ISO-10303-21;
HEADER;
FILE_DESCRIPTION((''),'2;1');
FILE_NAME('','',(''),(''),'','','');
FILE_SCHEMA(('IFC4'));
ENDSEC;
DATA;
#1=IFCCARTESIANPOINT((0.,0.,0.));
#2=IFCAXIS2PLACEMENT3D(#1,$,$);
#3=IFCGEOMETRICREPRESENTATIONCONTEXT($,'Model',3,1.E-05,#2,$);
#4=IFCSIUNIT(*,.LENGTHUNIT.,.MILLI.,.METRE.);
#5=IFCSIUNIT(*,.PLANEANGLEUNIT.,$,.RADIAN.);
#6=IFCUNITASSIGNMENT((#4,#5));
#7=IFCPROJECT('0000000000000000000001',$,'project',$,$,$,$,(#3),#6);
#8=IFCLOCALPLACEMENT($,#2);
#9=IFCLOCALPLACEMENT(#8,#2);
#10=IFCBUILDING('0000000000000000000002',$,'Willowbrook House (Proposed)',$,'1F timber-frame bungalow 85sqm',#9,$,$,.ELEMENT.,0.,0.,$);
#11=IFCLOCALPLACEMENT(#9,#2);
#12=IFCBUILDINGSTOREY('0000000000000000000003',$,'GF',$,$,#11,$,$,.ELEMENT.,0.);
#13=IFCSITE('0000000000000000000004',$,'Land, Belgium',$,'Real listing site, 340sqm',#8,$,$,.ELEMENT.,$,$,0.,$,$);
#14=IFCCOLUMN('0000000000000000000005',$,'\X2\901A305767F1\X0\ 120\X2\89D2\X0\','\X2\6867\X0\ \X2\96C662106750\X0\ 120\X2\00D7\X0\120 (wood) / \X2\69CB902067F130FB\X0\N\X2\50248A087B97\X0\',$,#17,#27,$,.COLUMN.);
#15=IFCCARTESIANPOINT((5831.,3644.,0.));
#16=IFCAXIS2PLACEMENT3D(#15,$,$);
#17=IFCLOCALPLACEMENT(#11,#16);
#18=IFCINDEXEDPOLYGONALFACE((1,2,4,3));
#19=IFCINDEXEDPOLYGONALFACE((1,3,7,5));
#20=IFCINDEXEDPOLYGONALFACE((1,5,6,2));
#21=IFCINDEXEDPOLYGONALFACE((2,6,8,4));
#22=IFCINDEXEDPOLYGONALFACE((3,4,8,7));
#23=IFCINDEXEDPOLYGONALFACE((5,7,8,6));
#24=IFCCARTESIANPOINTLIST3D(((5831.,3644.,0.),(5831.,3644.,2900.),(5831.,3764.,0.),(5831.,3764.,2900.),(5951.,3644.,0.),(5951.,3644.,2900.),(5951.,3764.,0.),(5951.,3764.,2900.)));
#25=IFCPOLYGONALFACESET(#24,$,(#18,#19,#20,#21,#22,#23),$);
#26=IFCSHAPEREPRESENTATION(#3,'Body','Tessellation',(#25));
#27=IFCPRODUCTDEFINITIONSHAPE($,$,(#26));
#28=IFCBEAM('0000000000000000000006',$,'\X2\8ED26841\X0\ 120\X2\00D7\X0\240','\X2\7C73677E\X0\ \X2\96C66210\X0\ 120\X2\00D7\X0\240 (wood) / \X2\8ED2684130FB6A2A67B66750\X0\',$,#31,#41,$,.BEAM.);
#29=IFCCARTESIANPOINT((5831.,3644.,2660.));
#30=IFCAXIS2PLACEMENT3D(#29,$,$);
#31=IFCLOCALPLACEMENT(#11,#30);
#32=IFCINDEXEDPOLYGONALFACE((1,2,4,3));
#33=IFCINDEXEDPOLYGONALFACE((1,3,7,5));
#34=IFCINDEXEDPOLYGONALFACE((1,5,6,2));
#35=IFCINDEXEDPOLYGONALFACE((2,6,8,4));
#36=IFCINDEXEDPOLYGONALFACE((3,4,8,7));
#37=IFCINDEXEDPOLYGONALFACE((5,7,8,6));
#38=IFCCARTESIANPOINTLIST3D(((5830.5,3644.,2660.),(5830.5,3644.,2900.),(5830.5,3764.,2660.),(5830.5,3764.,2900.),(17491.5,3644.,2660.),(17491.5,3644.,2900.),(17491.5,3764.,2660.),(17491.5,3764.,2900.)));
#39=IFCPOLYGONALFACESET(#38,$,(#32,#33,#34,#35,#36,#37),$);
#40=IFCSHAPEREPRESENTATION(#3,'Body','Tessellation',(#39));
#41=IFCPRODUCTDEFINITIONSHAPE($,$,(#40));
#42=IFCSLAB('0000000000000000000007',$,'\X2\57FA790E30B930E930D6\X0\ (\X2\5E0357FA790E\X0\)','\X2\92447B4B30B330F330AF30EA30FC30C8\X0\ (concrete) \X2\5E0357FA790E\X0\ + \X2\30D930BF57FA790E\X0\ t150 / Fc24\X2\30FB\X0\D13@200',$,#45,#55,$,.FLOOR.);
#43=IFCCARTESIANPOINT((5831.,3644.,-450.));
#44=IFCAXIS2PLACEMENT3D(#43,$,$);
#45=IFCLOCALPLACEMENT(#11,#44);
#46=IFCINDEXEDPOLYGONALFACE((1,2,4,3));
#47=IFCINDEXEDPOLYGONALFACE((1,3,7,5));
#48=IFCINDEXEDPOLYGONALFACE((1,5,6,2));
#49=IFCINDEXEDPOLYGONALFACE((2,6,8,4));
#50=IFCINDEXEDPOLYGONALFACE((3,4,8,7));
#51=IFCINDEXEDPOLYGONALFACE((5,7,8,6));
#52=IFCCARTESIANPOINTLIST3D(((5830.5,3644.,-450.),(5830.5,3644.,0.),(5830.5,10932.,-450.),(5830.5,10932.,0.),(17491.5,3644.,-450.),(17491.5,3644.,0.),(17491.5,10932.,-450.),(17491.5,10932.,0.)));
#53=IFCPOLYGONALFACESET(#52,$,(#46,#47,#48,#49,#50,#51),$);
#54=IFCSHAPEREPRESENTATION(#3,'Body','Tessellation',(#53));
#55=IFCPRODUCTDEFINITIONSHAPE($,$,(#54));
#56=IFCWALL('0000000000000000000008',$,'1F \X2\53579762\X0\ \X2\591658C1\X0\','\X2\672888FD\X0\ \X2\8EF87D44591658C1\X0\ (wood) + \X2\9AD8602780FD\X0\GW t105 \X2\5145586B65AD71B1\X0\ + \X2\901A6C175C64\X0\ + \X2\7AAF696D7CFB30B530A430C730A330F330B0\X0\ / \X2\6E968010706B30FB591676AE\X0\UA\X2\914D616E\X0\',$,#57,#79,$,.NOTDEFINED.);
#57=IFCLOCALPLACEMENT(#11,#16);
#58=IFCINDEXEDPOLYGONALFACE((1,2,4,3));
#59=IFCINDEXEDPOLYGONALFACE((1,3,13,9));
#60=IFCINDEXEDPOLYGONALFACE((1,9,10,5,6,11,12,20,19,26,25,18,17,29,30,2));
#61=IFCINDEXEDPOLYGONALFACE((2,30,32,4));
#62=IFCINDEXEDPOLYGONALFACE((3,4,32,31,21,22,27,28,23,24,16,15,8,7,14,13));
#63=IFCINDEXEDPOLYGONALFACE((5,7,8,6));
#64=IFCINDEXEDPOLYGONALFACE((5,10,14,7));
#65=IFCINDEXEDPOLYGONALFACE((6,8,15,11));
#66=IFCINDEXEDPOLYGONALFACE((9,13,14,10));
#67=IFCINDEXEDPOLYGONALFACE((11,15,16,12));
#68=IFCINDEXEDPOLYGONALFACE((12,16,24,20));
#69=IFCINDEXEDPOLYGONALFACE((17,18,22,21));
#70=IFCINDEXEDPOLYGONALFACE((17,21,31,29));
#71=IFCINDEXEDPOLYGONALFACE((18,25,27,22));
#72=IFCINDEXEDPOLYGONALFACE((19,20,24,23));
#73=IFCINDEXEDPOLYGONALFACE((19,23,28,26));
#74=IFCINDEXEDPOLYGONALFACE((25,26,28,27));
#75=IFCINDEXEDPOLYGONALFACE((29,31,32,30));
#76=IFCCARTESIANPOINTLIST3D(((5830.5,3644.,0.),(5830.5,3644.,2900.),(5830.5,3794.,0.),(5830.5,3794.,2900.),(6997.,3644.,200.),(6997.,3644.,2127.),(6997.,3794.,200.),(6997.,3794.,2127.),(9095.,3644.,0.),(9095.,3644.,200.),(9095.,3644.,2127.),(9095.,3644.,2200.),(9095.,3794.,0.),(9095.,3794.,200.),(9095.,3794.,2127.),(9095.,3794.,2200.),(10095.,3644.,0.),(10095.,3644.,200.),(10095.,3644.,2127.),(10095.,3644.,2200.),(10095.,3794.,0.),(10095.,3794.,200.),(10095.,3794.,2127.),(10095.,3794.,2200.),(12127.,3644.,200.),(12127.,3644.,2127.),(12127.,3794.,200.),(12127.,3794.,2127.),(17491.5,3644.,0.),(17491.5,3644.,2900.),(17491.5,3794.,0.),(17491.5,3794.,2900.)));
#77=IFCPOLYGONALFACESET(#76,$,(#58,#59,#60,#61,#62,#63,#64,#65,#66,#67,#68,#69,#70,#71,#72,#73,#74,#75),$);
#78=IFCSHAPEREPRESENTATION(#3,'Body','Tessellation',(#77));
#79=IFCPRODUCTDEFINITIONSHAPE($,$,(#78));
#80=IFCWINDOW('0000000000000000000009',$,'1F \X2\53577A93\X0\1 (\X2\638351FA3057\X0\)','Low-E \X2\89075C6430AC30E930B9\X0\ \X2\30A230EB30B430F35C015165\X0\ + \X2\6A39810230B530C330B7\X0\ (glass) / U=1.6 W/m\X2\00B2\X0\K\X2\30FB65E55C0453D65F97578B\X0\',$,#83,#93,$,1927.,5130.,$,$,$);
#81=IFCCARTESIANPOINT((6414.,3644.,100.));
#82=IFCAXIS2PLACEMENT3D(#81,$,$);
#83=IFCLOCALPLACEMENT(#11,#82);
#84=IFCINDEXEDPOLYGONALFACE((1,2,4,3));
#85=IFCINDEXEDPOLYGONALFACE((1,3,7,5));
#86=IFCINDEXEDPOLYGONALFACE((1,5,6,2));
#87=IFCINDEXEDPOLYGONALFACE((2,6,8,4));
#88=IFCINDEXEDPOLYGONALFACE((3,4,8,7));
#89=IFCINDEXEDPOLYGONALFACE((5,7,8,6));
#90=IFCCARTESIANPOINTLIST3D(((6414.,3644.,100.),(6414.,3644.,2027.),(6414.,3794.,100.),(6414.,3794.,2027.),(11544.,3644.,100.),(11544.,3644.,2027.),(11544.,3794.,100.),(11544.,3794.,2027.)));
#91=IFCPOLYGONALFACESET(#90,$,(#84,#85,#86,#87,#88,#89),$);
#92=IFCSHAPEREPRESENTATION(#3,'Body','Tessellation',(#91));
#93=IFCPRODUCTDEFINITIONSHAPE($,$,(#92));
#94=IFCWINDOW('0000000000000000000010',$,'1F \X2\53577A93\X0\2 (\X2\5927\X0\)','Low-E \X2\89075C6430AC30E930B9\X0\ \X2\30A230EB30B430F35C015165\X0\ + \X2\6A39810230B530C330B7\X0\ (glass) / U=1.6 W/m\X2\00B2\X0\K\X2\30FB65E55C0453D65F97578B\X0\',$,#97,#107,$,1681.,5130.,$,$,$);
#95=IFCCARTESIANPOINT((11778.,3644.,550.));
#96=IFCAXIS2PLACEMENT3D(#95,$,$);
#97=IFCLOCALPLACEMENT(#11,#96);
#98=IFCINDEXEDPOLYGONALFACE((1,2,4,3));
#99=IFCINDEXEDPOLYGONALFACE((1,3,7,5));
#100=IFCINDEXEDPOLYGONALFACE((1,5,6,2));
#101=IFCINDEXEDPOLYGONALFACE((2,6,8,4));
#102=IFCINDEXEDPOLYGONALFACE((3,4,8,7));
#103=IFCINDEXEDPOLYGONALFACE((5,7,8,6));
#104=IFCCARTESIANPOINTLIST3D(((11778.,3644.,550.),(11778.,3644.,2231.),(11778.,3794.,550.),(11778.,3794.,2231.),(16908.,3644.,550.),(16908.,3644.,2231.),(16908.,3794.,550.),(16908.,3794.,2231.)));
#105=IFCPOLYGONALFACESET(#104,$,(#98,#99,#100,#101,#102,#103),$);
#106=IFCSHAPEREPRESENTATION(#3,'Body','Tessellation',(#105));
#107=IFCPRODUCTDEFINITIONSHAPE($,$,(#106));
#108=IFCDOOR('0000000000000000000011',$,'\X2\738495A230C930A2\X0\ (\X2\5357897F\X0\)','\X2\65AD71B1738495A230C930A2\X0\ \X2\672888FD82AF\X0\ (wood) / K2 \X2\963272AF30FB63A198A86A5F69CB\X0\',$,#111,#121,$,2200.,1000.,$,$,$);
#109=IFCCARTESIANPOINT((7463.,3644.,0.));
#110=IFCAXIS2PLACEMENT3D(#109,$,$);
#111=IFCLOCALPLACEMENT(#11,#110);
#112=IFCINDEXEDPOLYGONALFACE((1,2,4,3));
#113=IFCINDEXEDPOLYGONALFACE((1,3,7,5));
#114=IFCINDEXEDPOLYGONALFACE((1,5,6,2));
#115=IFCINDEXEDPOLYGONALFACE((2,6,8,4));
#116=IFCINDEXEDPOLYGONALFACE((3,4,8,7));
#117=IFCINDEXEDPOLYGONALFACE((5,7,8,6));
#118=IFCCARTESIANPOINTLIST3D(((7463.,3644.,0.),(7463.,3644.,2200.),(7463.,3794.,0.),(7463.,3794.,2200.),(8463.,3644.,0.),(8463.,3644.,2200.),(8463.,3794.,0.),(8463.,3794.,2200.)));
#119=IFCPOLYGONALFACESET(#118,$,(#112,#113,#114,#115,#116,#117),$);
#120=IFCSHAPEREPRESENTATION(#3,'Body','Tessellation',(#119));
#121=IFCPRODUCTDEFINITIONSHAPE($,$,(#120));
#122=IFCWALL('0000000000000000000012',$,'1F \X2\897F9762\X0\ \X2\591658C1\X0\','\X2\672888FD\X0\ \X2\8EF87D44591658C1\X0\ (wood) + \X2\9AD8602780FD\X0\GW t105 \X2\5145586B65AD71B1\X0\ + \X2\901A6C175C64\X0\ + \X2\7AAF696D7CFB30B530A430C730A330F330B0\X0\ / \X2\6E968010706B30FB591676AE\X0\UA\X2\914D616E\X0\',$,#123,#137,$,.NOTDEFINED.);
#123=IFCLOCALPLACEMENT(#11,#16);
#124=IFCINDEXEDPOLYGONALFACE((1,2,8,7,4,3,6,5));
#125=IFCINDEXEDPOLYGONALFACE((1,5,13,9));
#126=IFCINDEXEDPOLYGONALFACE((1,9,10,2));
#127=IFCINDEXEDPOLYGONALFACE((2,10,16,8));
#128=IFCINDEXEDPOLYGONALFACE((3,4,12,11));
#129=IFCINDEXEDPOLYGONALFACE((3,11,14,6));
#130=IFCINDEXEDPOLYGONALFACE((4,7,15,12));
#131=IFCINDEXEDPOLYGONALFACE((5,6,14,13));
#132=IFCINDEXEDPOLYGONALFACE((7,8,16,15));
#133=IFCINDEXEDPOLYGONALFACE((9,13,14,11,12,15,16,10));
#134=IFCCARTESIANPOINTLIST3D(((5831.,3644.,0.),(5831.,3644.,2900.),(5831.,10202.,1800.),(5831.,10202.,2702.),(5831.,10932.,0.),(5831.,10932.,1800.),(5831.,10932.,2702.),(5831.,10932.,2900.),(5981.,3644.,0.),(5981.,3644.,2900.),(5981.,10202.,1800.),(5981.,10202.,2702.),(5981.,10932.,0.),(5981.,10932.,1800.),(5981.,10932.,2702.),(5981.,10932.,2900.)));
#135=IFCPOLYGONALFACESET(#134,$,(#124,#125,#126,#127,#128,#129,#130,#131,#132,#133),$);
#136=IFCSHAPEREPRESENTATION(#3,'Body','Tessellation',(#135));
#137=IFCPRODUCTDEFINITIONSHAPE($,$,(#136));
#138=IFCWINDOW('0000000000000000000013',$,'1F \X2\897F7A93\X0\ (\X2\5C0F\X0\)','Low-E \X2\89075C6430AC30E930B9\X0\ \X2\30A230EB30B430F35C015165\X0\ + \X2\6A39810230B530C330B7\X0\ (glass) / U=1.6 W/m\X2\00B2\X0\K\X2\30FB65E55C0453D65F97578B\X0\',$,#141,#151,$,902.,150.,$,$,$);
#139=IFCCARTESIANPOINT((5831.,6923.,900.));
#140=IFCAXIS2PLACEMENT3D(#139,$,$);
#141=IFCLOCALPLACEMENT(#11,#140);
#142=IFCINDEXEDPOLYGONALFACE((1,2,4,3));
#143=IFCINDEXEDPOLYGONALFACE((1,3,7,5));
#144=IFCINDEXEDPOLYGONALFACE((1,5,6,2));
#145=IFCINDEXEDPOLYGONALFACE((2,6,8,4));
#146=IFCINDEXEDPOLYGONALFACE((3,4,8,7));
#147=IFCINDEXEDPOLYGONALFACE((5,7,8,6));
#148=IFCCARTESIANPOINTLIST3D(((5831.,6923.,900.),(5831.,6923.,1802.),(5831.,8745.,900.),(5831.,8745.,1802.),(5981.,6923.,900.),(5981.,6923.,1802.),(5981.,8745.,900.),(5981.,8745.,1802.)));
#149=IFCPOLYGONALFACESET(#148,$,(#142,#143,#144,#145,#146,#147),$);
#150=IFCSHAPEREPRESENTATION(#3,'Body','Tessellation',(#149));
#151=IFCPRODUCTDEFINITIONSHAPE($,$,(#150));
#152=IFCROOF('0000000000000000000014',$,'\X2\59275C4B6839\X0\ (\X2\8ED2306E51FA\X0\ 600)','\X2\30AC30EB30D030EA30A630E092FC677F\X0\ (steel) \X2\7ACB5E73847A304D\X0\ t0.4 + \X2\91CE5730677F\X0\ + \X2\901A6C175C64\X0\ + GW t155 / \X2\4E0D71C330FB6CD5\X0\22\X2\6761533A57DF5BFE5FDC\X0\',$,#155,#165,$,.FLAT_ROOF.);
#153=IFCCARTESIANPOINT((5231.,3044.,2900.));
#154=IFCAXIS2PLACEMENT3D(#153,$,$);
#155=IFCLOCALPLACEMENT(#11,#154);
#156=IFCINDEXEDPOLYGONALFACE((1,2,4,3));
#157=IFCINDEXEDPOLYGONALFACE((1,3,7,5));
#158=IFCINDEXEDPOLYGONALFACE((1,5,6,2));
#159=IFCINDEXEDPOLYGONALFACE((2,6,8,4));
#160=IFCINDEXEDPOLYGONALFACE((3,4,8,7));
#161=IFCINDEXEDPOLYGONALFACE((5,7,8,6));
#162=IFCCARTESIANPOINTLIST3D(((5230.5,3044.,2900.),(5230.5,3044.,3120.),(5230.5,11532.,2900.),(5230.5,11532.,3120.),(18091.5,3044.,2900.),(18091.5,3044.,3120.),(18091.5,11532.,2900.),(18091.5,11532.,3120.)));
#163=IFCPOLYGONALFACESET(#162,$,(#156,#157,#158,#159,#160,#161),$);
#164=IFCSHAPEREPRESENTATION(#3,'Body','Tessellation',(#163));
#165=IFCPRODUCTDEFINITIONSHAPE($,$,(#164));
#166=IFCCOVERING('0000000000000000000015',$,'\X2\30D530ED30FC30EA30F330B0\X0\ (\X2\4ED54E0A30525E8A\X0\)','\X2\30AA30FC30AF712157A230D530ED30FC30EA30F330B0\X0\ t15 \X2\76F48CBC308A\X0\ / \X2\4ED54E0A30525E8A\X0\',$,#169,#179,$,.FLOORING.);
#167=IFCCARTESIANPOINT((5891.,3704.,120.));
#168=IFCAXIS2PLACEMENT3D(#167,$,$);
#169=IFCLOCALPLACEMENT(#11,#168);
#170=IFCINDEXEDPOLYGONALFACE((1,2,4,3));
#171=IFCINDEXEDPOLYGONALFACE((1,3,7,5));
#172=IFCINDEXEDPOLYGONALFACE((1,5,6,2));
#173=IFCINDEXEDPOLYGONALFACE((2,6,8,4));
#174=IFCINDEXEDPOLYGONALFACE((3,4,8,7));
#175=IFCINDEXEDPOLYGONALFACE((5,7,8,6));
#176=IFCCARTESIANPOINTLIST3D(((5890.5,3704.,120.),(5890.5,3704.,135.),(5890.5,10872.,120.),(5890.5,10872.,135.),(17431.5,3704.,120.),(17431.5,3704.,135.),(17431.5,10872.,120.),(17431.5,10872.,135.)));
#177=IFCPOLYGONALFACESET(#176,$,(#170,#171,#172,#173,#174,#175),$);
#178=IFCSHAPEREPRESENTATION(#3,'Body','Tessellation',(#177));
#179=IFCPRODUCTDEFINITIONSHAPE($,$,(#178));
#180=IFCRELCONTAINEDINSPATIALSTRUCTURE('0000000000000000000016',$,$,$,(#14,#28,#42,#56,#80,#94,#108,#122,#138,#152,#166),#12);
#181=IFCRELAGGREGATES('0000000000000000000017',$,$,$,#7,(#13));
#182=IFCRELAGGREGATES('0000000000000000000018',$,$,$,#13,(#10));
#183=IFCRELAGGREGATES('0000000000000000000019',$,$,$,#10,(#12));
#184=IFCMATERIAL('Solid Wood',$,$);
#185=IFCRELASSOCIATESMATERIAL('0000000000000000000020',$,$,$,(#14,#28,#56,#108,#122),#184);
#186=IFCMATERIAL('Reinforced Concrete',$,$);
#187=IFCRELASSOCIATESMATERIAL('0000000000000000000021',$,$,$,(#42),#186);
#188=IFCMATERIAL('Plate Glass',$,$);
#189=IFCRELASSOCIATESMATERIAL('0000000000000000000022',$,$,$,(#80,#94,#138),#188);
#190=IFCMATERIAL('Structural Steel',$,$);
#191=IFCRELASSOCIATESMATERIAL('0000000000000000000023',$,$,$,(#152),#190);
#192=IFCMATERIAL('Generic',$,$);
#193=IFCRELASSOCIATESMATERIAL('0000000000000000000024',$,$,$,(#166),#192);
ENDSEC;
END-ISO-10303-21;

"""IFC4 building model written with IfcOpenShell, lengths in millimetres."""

from ifc_helpers import new_model, si_unit, frame, frame_2d, origin, place, context, project, spatial, rectangle, extrude, material, element, fill, save


model = new_model("IFC4")

# Units and contexts
model_context = context("Model", 3, precision=1e-05, world=origin())
ifc_project = project(units=[si_unit("LENGTHUNIT", "METRE", prefix="MILLI"), si_unit("PLANEANGLEUNIT", "RADIAN")], contexts=[model_context])

# Site, building, storey
site_placement = place(None, origin())
site = spatial("IfcSite", under=ifc_project, at=site_placement, Name="Land, Belgium", ObjectType="Real listing site, 340sqm", CompositionType="ELEMENT", RefElevation=0.0)
building_placement = place(site_placement, origin())
building = spatial("IfcBuilding", under=site, at=building_placement, Name="Willowbrook House (Proposed)", ObjectType="1F timber-frame bungalow 85sqm", CompositionType="ELEMENT", ElevationOfRefHeight=0.0, ElevationOfTerrain=0.0)
storey_placement = place(building_placement, origin())
storey = spatial("IfcBuildingStorey", under=building, at=storey_placement, Name="GF", CompositionType="ELEMENT", Elevation=0.0)

# Column
ifc_material_1 = material(Name="Solid Wood")
column_1_placement = place(storey_placement, frame((5831.0, 3644.0, 0.0)))
element("IfcColumn", 1, at=column_1_placement, inside=storey, material=ifc_material_1, Name="通し柱 120角", Description="桧 集成材 120×120 (wood) / 構造柱・N値計算", PredefinedType="COLUMN", context=model_context, shape_type="SweptSolid", body=[
    extrude(rectangle(XDim=120.0, YDim=120.0, at=frame_2d((60.0, 60.0))), frame((5831.0, 3644.0, 0.0)), (0.0, 0.0, 1.0), 2900.0),
])

# Beam
beam_1_placement = place(storey_placement, frame((5831.0, 3644.0, 2660.0)))
element("IfcBeam", 2, at=beam_1_placement, inside=storey, material=ifc_material_1, Name="軒桁 120×240", Description="米松 集成 120×240 (wood) / 軒桁・横架材", PredefinedType="BEAM", context=model_context, shape_type="SweptSolid", body=[
    extrude(rectangle(XDim=11661.0, YDim=120.0, at=frame_2d((5830.0, 60.0))), frame((5831.0, 3644.0, 2660.0)), (0.0, 0.0, 1.0), 240.0),
])

# Slab
ifc_material_2 = material(Name="Reinforced Concrete")
slab_1_placement = place(storey_placement, frame((5831.0, 3644.0, -450.0)))
element("IfcSlab", 3, at=slab_1_placement, inside=storey, material=ifc_material_2, Name="基礎スラブ (布基礎)", Description="鉄筋コンクリート (concrete) 布基礎 + ベタ基礎 t150 / Fc24・D13@200", PredefinedType="FLOOR", context=model_context, shape_type="SweptSolid", body=[
    extrude(rectangle(XDim=11661.0, YDim=7288.0, at=frame_2d((5830.0, 3644.0))), frame((5831.0, 3644.0, -450.0)), (0.0, 0.0, 1.0), 450.0),
])

# Wall, openings, windows, door
wall_1_placement = place(storey_placement, frame((5831.0, 3644.0, 0.0)))
wall_1 = element("IfcWall", 4, at=wall_1_placement, inside=storey, material=ifc_material_1, Name="1F 南面 外壁", Description="木製 軸組外壁 (wood) + 高性能GW t105 充填断熱 + 通気層 + 窯業系サイディング / 準耐火・外皮UA配慮", PredefinedType="NOTDEFINED", context=model_context, shape_type="SweptSolid", body=[
    extrude(rectangle(XDim=11661.0, YDim=150.0, at=frame_2d((5830.0, 75.0))), frame((5831.0, 3644.0, 0.0)), (0.0, 0.0, 1.0), 2900.0),
])
opening_1_placement = place(storey_placement, frame((6414.0, 3644.0, 100.0)))
opening_1 = element("IfcOpeningElement", 5, at=opening_1_placement, cuts=wall_1, PredefinedType="NOTDEFINED", context=model_context, shape_type="SweptSolid", body=[
    extrude(rectangle(XDim=5130.0, YDim=150.0, at=frame_2d((2565.0, 75.0))), frame((6414.0, 3644.0, 100.0)), (0.0, 0.0, 1.0), 1927.0),
])
opening_2_placement = place(storey_placement, frame((11778.0, 3644.0, 550.0)))
opening_2 = element("IfcOpeningElement", 6, at=opening_2_placement, cuts=wall_1, PredefinedType="NOTDEFINED", context=model_context, shape_type="SweptSolid", body=[
    extrude(rectangle(XDim=5130.0, YDim=150.0, at=frame_2d((2565.0, 75.0))), frame((11778.0, 3644.0, 550.0)), (0.0, 0.0, 1.0), 1681.0),
])
opening_3_placement = place(storey_placement, frame((7463.0, 3644.0, 0.0)))
opening_3 = element("IfcOpeningElement", 7, at=opening_3_placement, cuts=wall_1, PredefinedType="NOTDEFINED", context=model_context, shape_type="SweptSolid", body=[
    extrude(rectangle(XDim=1000.0, YDim=150.0, at=frame_2d((500.0, 75.0))), frame((7463.0, 3644.0, 0.0)), (0.0, 0.0, 1.0), 2200.0),
])
ifc_material_3 = material(Name="Plate Glass")
window_1_placement = place(storey_placement, frame((6414.0, 3644.0, 100.0)))
window_1 = element("IfcWindow", 8, at=window_1_placement, inside=storey, material=ifc_material_3, Name="1F 南窓1 (掃出し)", Description="Low-E 複層ガラス アルゴン封入 + 樹脂サッシ (glass) / U=1.6 W/m²K・日射取得型", OverallHeight=1927.0, OverallWidth=5130.0, context=model_context, shape_type="SweptSolid", body=[
    extrude(rectangle(XDim=5130.0, YDim=150.0, at=frame_2d((2565.0, 75.0))), frame((6414.0, 3644.0, 100.0)), (0.0, 0.0, 1.0), 1927.0),
])
fill(opening_1, window_1)
window_2_placement = place(storey_placement, frame((11778.0, 3644.0, 550.0)))
window_2 = element("IfcWindow", 9, at=window_2_placement, inside=storey, material=ifc_material_3, Name="1F 南窓2 (大)", Description="Low-E 複層ガラス アルゴン封入 + 樹脂サッシ (glass) / U=1.6 W/m²K・日射取得型", OverallHeight=1681.0, OverallWidth=5130.0, context=model_context, shape_type="SweptSolid", body=[
    extrude(rectangle(XDim=5130.0, YDim=150.0, at=frame_2d((2565.0, 75.0))), frame((11778.0, 3644.0, 550.0)), (0.0, 0.0, 1.0), 1681.0),
])
fill(opening_2, window_2)
door_placement = place(storey_placement, frame((7463.0, 3644.0, 0.0)))
door = element("IfcDoor", 10, at=door_placement, inside=storey, material=ifc_material_1, Name="玄関ドア (南西)", Description="断熱玄関ドア 木製芯 (wood) / K2 防犯・採風機構", OverallHeight=2200.0, OverallWidth=1000.0, context=model_context, shape_type="SweptSolid", body=[
    extrude(rectangle(XDim=1000.0, YDim=150.0, at=frame_2d((500.0, 75.0))), frame((7463.0, 3644.0, 0.0)), (0.0, 0.0, 1.0), 2200.0),
])
fill(opening_3, door)

# Wall, opening, window
wall_2_placement = place(storey_placement, frame((5831.0, 3644.0, 0.0)))
wall_2 = element("IfcWall", 11, at=wall_2_placement, inside=storey, material=ifc_material_1, Name="1F 西面 外壁", Description="木製 軸組外壁 (wood) + 高性能GW t105 充填断熱 + 通気層 + 窯業系サイディング / 準耐火・外皮UA配慮", PredefinedType="NOTDEFINED", context=model_context, shape_type="SweptSolid", body=[
    extrude(rectangle(XDim=150.0, YDim=7288.0, at=frame_2d((75.0, 3644.0))), frame((5831.0, 3644.0, 0.0)), (0.0, 0.0, 1.0), 2900.0),
])
opening_4_placement = place(storey_placement, frame((5831.0, 6923.0, 900.0)))
opening_4 = element("IfcOpeningElement", 12, at=opening_4_placement, cuts=wall_2, PredefinedType="NOTDEFINED", context=model_context, shape_type="SweptSolid", body=[
    extrude(rectangle(XDim=150.0, YDim=1822.0, at=frame_2d((75.0, 911.0))), frame((5831.0, 6923.0, 900.0)), (0.0, 0.0, 1.0), 902.0),
])
window_3_placement = place(storey_placement, frame((5831.0, 6923.0, 900.0)))
window_3 = element("IfcWindow", 13, at=window_3_placement, inside=storey, material=ifc_material_3, Name="1F 西窓 (小)", Description="Low-E 複層ガラス アルゴン封入 + 樹脂サッシ (glass) / U=1.6 W/m²K・日射取得型", OverallHeight=902.0, OverallWidth=150.0, context=model_context, shape_type="SweptSolid", body=[
    extrude(rectangle(XDim=150.0, YDim=1822.0, at=frame_2d((75.0, 911.0))), frame((5831.0, 6923.0, 900.0)), (0.0, 0.0, 1.0), 902.0),
])
fill(opening_4, window_3)

# Roof
ifc_material_4 = material(Name="Structural Steel")
roof_placement = place(storey_placement, frame((5231.0, 3044.0, 2900.0)))
element("IfcRoof", 14, at=roof_placement, inside=storey, material=ifc_material_4, Name="大屋根 (軒の出 600)", Description="ガルバリウム鋼板 (steel) 立平葺き t0.4 + 野地板 + 通気層 + GW t155 / 不燃・法22条区域対応", PredefinedType="FLAT_ROOF", context=model_context, shape_type="SweptSolid", body=[
    extrude(rectangle(XDim=12861.0, YDim=8488.0, at=frame_2d((6430.0, 4244.0))), frame((5231.0, 3044.0, 2900.0)), (0.0, 0.0, 1.0), 220.0),
])

# Covering
ifc_material_5 = material(Name="Generic")
covering_1_placement = place(storey_placement, frame((5891.0, 3704.0, 120.0)))
element("IfcCovering", 15, at=covering_1_placement, inside=storey, material=ifc_material_5, Name="フローリング (仕上げ床)", Description="オーク無垢フローリング t15 直貼り / 仕上げ床", PredefinedType="FLOORING", context=model_context, shape_type="SweptSolid", body=[
    extrude(rectangle(XDim=11541.0, YDim=7168.0, at=frame_2d((5770.0, 3584.0))), frame((5891.0, 3704.0, 120.0)), (0.0, 0.0, 1.0), 15.0),
])

save(model, "model.ifc")
